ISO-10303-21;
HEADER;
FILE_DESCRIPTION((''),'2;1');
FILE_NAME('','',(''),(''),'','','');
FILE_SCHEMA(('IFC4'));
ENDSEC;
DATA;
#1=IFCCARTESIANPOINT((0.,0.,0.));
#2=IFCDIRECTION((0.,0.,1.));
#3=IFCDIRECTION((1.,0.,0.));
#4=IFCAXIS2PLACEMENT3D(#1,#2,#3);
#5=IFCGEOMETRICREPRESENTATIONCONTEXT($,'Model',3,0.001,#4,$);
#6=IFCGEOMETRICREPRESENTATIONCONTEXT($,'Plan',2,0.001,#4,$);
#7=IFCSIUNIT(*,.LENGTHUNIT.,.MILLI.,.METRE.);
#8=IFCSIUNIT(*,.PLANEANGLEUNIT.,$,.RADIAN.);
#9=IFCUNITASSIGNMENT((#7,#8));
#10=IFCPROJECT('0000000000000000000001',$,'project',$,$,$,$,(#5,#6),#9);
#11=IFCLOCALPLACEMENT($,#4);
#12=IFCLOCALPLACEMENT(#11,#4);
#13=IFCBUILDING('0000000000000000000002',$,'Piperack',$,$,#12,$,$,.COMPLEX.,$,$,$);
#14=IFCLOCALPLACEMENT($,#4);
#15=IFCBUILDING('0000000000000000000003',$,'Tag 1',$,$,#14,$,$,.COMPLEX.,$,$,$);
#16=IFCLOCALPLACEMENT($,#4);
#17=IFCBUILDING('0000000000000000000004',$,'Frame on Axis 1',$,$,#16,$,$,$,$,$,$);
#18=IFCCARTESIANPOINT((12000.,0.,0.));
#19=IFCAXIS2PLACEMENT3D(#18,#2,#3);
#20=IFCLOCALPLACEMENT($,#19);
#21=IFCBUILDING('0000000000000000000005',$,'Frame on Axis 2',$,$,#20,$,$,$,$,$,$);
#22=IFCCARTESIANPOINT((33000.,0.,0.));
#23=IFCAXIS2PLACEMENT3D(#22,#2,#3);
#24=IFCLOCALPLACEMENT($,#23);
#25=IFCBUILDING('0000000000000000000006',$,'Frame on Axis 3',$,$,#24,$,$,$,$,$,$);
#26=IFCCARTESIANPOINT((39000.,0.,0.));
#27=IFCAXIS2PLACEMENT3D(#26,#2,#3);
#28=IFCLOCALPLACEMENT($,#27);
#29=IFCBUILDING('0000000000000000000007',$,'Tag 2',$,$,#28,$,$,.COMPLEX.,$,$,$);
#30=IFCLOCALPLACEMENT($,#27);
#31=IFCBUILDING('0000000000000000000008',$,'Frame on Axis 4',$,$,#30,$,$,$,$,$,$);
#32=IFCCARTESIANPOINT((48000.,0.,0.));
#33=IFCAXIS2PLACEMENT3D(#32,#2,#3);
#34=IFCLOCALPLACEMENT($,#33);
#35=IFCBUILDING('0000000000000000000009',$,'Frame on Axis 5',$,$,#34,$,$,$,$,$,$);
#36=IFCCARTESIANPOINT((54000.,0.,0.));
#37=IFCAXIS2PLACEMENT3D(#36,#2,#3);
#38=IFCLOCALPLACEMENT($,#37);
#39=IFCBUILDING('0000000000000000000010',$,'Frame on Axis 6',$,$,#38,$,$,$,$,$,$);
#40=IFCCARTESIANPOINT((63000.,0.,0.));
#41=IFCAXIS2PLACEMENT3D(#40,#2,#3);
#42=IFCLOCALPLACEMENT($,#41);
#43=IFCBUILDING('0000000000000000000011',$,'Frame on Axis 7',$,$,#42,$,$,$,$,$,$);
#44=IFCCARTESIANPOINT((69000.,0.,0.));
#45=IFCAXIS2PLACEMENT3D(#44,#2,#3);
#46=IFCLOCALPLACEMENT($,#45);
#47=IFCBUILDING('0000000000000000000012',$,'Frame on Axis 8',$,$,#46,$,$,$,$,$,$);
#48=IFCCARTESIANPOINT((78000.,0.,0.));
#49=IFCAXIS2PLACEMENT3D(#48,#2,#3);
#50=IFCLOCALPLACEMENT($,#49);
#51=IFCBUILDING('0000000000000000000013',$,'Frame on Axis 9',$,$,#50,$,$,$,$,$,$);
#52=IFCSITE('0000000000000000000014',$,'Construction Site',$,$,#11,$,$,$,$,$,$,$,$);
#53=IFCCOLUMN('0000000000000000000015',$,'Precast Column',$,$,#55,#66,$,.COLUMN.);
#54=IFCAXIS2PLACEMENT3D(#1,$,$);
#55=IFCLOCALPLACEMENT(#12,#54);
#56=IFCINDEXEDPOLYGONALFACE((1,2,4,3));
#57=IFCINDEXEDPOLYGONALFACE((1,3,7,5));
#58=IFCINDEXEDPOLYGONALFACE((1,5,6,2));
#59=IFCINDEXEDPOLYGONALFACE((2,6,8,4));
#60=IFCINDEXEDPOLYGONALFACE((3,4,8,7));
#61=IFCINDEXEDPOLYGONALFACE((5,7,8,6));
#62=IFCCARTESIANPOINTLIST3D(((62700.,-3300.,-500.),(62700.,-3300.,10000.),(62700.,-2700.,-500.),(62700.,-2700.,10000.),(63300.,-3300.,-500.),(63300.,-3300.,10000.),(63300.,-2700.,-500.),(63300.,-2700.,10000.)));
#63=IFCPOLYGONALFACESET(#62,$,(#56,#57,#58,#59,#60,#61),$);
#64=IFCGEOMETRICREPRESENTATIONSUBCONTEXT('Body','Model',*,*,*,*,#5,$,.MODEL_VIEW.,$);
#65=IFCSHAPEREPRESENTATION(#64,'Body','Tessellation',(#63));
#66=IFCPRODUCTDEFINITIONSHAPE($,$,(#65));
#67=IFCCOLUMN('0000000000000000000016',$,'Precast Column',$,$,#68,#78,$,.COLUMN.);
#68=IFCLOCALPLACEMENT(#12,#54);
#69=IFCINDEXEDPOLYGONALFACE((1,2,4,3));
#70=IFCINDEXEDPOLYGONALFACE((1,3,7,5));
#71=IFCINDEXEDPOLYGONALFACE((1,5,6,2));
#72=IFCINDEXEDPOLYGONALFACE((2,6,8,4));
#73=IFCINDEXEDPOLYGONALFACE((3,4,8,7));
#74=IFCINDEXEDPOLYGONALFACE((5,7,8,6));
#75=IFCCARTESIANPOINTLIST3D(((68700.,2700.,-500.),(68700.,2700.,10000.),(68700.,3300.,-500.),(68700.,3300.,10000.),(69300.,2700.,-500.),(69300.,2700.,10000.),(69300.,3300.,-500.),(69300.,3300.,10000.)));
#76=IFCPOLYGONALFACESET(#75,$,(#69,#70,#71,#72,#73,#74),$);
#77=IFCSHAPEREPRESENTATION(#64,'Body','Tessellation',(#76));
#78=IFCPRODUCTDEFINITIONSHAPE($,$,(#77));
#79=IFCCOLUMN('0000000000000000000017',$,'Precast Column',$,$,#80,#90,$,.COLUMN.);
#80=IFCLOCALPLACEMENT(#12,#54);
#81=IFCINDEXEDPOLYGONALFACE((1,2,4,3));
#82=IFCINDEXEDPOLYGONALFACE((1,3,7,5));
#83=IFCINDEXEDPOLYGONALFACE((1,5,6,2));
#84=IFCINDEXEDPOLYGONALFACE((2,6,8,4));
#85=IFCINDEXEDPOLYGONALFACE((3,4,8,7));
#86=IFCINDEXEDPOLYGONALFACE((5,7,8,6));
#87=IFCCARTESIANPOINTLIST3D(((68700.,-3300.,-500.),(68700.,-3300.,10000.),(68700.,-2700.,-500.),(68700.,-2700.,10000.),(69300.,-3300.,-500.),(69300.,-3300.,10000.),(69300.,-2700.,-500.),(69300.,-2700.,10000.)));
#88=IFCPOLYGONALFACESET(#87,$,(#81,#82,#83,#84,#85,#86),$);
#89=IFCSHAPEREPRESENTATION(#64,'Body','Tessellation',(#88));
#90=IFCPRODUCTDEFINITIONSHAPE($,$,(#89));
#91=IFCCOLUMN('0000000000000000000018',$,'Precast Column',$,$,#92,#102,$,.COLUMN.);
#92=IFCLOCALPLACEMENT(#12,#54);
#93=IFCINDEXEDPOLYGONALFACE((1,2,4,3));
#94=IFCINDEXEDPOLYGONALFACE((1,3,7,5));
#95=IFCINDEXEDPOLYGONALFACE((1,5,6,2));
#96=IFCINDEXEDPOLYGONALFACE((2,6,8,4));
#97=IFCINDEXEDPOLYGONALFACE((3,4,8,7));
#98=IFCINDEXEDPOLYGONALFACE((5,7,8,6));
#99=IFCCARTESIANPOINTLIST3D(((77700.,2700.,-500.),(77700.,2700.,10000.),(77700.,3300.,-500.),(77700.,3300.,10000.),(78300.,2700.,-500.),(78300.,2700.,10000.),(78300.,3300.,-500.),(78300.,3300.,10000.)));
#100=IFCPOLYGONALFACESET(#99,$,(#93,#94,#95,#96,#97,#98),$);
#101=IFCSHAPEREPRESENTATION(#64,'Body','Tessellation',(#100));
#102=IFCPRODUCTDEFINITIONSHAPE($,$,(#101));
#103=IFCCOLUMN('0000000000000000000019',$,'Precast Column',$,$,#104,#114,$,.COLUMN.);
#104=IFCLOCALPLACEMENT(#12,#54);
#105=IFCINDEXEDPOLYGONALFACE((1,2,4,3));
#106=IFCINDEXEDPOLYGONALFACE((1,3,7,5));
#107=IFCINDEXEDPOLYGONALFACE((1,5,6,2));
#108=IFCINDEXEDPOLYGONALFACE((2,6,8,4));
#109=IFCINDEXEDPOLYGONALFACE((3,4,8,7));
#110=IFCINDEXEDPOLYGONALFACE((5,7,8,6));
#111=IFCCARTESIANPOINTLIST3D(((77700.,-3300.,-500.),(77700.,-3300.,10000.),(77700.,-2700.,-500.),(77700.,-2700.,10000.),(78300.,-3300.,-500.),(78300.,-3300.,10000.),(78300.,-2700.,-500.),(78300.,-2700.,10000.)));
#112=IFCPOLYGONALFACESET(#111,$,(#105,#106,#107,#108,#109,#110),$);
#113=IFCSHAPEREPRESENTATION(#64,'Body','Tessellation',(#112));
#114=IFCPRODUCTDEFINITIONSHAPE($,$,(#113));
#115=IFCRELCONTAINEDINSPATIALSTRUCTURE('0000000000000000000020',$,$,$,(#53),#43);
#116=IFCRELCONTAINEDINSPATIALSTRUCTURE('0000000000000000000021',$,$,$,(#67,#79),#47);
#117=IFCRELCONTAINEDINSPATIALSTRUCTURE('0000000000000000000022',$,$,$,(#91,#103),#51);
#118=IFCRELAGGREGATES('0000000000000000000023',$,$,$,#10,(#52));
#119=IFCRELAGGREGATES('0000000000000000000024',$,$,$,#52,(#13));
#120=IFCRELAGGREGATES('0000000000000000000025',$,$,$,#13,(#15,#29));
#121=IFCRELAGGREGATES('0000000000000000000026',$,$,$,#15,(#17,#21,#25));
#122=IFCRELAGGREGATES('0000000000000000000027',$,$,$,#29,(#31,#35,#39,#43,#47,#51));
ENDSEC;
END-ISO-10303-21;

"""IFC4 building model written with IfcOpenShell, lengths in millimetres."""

from ifc_helpers import new_model, si_unit, frame, origin_with_axes, place, context, subcontext, project, spatial, rectangle, extrude, element, save


model = new_model("IFC4")

# Units and contexts
model_context = context("Model", 3, precision=0.001, world=origin_with_axes())
plan_context = context("Plan", 2, precision=0.001, world=origin_with_axes())
body_context = subcontext(model_context, "Body", "Model", "MODEL_VIEW")
ifc_project = project(units=[si_unit("LENGTHUNIT", "METRE", prefix="MILLI"), si_unit("PLANEANGLEUNIT", "RADIAN")], contexts=[model_context, plan_context])

# Site, buildings
site_placement = place(None, origin_with_axes())
site = spatial("IfcSite", under=ifc_project, at=site_placement, Name="Construction Site")
building_1_placement = place(site_placement, origin_with_axes())
building_1 = spatial("IfcBuilding", under=site, at=building_1_placement, Name="Piperack", CompositionType="COMPLEX")
building_2_placement = place(None, origin_with_axes())
building_2 = spatial("IfcBuilding", under=building_1, at=building_2_placement, Name="Tag 1", CompositionType="COMPLEX")
building_3_placement = place(None, origin_with_axes())
building_3 = spatial("IfcBuilding", under=building_2, at=building_3_placement, Name="Frame on Axis 1")

# Shared definitions
building_4_placement = place(None, frame((12000.0, 0.0, 0.0), z_axis=(0.0, 0.0, 1.0), x_axis=(1.0, 0.0, 0.0)))
building_4 = spatial("IfcBuilding", under=building_2, at=building_4_placement, Name="Frame on Axis 2")

# Shared definitions
building_5_placement = place(None, frame((33000.0, 0.0, 0.0), z_axis=(0.0, 0.0, 1.0), x_axis=(1.0, 0.0, 0.0)))
building_5 = spatial("IfcBuilding", under=building_2, at=building_5_placement, Name="Frame on Axis 3")

# Shared definitions
building_6_placement = place(None, frame((39000.0, 0.0, 0.0), z_axis=(0.0, 0.0, 1.0), x_axis=(1.0, 0.0, 0.0)))
building_6 = spatial("IfcBuilding", under=building_1, at=building_6_placement, Name="Tag 2", CompositionType="COMPLEX")
building_7_placement = place(None, frame((39000.0, 0.0, 0.0), z_axis=(0.0, 0.0, 1.0), x_axis=(1.0, 0.0, 0.0)))
building_7 = spatial("IfcBuilding", under=building_6, at=building_7_placement, Name="Frame on Axis 4")

# Shared definitions
building_8_placement = place(None, frame((48000.0, 0.0, 0.0), z_axis=(0.0, 0.0, 1.0), x_axis=(1.0, 0.0, 0.0)))
building_8 = spatial("IfcBuilding", under=building_6, at=building_8_placement, Name="Frame on Axis 5")

# Shared definitions
building_9_placement = place(None, frame((54000.0, 0.0, 0.0), z_axis=(0.0, 0.0, 1.0), x_axis=(1.0, 0.0, 0.0)))
building_9 = spatial("IfcBuilding", under=building_6, at=building_9_placement, Name="Frame on Axis 6")

# Shared definitions
building_10_placement = place(None, frame((63000.0, 0.0, 0.0), z_axis=(0.0, 0.0, 1.0), x_axis=(1.0, 0.0, 0.0)))
building_10 = spatial("IfcBuilding", under=building_6, at=building_10_placement, Name="Frame on Axis 7")

# Column
for number, where, z_axis, x_axis, name in (
    (1, (0.0, -3000.0, -500.0), (0.0, 0.0, 1.0), (1.0, 0.0, 0.0), "Precast Column"),
):
    element("IfcColumn", number, at=place(building_10_placement, frame(where, z_axis=z_axis, x_axis=x_axis)), inside=building_10, Name=name, PredefinedType="COLUMN", context=body_context, shape_type="SweptSolid", body=[
        extrude(rectangle(XDim=600.0, YDim=600.0), None, (0.0, 0.0, 1.0), 10500.0),
    ])

# Shared definitions
building_11_placement = place(None, frame((69000.0, 0.0, 0.0), z_axis=(0.0, 0.0, 1.0), x_axis=(1.0, 0.0, 0.0)))
building_11 = spatial("IfcBuilding", under=building_6, at=building_11_placement, Name="Frame on Axis 8")

# Columns
for number, where, z_axis, x_axis, name in (
    (2, (0.0, 3000.0, -500.0), (0.0, 0.0, 1.0), (1.0, 0.0, 0.0), "Precast Column"),
    (3, (0.0, -3000.0, -500.0), (0.0, 0.0, 1.0), (1.0, 0.0, 0.0), "Precast Column"),
):
    element("IfcColumn", number, at=place(building_11_placement, frame(where, z_axis=z_axis, x_axis=x_axis)), inside=building_11, Name=name, PredefinedType="COLUMN", context=body_context, shape_type="SweptSolid", body=[
        extrude(rectangle(XDim=600.0, YDim=600.0), None, (0.0, 0.0, 1.0), 10500.0),
    ])

# Shared definitions
building_12_placement = place(None, frame((78000.0, 0.0, 0.0), z_axis=(0.0, 0.0, 1.0), x_axis=(1.0, 0.0, 0.0)))
building_12 = spatial("IfcBuilding", under=building_6, at=building_12_placement, Name="Frame on Axis 9")

# Columns
for number, where, z_axis, x_axis, name in (
    (4, (0.0, 3000.0, -500.0), (0.0, 0.0, 1.0), (1.0, 0.0, 0.0), "Precast Column"),
    (5, (0.0, -3000.0, -500.0), (0.0, 0.0, 1.0), (1.0, 0.0, 0.0), "Precast Column"),
):
    element("IfcColumn", number, at=place(building_12_placement, frame(where, z_axis=z_axis, x_axis=x_axis)), inside=building_12, Name=name, PredefinedType="COLUMN", context=body_context, shape_type="SweptSolid", body=[
        extrude(rectangle(XDim=600.0, YDim=600.0), None, (0.0, 0.0, 1.0), 10500.0),
    ])

save(model, "model.ifc")
